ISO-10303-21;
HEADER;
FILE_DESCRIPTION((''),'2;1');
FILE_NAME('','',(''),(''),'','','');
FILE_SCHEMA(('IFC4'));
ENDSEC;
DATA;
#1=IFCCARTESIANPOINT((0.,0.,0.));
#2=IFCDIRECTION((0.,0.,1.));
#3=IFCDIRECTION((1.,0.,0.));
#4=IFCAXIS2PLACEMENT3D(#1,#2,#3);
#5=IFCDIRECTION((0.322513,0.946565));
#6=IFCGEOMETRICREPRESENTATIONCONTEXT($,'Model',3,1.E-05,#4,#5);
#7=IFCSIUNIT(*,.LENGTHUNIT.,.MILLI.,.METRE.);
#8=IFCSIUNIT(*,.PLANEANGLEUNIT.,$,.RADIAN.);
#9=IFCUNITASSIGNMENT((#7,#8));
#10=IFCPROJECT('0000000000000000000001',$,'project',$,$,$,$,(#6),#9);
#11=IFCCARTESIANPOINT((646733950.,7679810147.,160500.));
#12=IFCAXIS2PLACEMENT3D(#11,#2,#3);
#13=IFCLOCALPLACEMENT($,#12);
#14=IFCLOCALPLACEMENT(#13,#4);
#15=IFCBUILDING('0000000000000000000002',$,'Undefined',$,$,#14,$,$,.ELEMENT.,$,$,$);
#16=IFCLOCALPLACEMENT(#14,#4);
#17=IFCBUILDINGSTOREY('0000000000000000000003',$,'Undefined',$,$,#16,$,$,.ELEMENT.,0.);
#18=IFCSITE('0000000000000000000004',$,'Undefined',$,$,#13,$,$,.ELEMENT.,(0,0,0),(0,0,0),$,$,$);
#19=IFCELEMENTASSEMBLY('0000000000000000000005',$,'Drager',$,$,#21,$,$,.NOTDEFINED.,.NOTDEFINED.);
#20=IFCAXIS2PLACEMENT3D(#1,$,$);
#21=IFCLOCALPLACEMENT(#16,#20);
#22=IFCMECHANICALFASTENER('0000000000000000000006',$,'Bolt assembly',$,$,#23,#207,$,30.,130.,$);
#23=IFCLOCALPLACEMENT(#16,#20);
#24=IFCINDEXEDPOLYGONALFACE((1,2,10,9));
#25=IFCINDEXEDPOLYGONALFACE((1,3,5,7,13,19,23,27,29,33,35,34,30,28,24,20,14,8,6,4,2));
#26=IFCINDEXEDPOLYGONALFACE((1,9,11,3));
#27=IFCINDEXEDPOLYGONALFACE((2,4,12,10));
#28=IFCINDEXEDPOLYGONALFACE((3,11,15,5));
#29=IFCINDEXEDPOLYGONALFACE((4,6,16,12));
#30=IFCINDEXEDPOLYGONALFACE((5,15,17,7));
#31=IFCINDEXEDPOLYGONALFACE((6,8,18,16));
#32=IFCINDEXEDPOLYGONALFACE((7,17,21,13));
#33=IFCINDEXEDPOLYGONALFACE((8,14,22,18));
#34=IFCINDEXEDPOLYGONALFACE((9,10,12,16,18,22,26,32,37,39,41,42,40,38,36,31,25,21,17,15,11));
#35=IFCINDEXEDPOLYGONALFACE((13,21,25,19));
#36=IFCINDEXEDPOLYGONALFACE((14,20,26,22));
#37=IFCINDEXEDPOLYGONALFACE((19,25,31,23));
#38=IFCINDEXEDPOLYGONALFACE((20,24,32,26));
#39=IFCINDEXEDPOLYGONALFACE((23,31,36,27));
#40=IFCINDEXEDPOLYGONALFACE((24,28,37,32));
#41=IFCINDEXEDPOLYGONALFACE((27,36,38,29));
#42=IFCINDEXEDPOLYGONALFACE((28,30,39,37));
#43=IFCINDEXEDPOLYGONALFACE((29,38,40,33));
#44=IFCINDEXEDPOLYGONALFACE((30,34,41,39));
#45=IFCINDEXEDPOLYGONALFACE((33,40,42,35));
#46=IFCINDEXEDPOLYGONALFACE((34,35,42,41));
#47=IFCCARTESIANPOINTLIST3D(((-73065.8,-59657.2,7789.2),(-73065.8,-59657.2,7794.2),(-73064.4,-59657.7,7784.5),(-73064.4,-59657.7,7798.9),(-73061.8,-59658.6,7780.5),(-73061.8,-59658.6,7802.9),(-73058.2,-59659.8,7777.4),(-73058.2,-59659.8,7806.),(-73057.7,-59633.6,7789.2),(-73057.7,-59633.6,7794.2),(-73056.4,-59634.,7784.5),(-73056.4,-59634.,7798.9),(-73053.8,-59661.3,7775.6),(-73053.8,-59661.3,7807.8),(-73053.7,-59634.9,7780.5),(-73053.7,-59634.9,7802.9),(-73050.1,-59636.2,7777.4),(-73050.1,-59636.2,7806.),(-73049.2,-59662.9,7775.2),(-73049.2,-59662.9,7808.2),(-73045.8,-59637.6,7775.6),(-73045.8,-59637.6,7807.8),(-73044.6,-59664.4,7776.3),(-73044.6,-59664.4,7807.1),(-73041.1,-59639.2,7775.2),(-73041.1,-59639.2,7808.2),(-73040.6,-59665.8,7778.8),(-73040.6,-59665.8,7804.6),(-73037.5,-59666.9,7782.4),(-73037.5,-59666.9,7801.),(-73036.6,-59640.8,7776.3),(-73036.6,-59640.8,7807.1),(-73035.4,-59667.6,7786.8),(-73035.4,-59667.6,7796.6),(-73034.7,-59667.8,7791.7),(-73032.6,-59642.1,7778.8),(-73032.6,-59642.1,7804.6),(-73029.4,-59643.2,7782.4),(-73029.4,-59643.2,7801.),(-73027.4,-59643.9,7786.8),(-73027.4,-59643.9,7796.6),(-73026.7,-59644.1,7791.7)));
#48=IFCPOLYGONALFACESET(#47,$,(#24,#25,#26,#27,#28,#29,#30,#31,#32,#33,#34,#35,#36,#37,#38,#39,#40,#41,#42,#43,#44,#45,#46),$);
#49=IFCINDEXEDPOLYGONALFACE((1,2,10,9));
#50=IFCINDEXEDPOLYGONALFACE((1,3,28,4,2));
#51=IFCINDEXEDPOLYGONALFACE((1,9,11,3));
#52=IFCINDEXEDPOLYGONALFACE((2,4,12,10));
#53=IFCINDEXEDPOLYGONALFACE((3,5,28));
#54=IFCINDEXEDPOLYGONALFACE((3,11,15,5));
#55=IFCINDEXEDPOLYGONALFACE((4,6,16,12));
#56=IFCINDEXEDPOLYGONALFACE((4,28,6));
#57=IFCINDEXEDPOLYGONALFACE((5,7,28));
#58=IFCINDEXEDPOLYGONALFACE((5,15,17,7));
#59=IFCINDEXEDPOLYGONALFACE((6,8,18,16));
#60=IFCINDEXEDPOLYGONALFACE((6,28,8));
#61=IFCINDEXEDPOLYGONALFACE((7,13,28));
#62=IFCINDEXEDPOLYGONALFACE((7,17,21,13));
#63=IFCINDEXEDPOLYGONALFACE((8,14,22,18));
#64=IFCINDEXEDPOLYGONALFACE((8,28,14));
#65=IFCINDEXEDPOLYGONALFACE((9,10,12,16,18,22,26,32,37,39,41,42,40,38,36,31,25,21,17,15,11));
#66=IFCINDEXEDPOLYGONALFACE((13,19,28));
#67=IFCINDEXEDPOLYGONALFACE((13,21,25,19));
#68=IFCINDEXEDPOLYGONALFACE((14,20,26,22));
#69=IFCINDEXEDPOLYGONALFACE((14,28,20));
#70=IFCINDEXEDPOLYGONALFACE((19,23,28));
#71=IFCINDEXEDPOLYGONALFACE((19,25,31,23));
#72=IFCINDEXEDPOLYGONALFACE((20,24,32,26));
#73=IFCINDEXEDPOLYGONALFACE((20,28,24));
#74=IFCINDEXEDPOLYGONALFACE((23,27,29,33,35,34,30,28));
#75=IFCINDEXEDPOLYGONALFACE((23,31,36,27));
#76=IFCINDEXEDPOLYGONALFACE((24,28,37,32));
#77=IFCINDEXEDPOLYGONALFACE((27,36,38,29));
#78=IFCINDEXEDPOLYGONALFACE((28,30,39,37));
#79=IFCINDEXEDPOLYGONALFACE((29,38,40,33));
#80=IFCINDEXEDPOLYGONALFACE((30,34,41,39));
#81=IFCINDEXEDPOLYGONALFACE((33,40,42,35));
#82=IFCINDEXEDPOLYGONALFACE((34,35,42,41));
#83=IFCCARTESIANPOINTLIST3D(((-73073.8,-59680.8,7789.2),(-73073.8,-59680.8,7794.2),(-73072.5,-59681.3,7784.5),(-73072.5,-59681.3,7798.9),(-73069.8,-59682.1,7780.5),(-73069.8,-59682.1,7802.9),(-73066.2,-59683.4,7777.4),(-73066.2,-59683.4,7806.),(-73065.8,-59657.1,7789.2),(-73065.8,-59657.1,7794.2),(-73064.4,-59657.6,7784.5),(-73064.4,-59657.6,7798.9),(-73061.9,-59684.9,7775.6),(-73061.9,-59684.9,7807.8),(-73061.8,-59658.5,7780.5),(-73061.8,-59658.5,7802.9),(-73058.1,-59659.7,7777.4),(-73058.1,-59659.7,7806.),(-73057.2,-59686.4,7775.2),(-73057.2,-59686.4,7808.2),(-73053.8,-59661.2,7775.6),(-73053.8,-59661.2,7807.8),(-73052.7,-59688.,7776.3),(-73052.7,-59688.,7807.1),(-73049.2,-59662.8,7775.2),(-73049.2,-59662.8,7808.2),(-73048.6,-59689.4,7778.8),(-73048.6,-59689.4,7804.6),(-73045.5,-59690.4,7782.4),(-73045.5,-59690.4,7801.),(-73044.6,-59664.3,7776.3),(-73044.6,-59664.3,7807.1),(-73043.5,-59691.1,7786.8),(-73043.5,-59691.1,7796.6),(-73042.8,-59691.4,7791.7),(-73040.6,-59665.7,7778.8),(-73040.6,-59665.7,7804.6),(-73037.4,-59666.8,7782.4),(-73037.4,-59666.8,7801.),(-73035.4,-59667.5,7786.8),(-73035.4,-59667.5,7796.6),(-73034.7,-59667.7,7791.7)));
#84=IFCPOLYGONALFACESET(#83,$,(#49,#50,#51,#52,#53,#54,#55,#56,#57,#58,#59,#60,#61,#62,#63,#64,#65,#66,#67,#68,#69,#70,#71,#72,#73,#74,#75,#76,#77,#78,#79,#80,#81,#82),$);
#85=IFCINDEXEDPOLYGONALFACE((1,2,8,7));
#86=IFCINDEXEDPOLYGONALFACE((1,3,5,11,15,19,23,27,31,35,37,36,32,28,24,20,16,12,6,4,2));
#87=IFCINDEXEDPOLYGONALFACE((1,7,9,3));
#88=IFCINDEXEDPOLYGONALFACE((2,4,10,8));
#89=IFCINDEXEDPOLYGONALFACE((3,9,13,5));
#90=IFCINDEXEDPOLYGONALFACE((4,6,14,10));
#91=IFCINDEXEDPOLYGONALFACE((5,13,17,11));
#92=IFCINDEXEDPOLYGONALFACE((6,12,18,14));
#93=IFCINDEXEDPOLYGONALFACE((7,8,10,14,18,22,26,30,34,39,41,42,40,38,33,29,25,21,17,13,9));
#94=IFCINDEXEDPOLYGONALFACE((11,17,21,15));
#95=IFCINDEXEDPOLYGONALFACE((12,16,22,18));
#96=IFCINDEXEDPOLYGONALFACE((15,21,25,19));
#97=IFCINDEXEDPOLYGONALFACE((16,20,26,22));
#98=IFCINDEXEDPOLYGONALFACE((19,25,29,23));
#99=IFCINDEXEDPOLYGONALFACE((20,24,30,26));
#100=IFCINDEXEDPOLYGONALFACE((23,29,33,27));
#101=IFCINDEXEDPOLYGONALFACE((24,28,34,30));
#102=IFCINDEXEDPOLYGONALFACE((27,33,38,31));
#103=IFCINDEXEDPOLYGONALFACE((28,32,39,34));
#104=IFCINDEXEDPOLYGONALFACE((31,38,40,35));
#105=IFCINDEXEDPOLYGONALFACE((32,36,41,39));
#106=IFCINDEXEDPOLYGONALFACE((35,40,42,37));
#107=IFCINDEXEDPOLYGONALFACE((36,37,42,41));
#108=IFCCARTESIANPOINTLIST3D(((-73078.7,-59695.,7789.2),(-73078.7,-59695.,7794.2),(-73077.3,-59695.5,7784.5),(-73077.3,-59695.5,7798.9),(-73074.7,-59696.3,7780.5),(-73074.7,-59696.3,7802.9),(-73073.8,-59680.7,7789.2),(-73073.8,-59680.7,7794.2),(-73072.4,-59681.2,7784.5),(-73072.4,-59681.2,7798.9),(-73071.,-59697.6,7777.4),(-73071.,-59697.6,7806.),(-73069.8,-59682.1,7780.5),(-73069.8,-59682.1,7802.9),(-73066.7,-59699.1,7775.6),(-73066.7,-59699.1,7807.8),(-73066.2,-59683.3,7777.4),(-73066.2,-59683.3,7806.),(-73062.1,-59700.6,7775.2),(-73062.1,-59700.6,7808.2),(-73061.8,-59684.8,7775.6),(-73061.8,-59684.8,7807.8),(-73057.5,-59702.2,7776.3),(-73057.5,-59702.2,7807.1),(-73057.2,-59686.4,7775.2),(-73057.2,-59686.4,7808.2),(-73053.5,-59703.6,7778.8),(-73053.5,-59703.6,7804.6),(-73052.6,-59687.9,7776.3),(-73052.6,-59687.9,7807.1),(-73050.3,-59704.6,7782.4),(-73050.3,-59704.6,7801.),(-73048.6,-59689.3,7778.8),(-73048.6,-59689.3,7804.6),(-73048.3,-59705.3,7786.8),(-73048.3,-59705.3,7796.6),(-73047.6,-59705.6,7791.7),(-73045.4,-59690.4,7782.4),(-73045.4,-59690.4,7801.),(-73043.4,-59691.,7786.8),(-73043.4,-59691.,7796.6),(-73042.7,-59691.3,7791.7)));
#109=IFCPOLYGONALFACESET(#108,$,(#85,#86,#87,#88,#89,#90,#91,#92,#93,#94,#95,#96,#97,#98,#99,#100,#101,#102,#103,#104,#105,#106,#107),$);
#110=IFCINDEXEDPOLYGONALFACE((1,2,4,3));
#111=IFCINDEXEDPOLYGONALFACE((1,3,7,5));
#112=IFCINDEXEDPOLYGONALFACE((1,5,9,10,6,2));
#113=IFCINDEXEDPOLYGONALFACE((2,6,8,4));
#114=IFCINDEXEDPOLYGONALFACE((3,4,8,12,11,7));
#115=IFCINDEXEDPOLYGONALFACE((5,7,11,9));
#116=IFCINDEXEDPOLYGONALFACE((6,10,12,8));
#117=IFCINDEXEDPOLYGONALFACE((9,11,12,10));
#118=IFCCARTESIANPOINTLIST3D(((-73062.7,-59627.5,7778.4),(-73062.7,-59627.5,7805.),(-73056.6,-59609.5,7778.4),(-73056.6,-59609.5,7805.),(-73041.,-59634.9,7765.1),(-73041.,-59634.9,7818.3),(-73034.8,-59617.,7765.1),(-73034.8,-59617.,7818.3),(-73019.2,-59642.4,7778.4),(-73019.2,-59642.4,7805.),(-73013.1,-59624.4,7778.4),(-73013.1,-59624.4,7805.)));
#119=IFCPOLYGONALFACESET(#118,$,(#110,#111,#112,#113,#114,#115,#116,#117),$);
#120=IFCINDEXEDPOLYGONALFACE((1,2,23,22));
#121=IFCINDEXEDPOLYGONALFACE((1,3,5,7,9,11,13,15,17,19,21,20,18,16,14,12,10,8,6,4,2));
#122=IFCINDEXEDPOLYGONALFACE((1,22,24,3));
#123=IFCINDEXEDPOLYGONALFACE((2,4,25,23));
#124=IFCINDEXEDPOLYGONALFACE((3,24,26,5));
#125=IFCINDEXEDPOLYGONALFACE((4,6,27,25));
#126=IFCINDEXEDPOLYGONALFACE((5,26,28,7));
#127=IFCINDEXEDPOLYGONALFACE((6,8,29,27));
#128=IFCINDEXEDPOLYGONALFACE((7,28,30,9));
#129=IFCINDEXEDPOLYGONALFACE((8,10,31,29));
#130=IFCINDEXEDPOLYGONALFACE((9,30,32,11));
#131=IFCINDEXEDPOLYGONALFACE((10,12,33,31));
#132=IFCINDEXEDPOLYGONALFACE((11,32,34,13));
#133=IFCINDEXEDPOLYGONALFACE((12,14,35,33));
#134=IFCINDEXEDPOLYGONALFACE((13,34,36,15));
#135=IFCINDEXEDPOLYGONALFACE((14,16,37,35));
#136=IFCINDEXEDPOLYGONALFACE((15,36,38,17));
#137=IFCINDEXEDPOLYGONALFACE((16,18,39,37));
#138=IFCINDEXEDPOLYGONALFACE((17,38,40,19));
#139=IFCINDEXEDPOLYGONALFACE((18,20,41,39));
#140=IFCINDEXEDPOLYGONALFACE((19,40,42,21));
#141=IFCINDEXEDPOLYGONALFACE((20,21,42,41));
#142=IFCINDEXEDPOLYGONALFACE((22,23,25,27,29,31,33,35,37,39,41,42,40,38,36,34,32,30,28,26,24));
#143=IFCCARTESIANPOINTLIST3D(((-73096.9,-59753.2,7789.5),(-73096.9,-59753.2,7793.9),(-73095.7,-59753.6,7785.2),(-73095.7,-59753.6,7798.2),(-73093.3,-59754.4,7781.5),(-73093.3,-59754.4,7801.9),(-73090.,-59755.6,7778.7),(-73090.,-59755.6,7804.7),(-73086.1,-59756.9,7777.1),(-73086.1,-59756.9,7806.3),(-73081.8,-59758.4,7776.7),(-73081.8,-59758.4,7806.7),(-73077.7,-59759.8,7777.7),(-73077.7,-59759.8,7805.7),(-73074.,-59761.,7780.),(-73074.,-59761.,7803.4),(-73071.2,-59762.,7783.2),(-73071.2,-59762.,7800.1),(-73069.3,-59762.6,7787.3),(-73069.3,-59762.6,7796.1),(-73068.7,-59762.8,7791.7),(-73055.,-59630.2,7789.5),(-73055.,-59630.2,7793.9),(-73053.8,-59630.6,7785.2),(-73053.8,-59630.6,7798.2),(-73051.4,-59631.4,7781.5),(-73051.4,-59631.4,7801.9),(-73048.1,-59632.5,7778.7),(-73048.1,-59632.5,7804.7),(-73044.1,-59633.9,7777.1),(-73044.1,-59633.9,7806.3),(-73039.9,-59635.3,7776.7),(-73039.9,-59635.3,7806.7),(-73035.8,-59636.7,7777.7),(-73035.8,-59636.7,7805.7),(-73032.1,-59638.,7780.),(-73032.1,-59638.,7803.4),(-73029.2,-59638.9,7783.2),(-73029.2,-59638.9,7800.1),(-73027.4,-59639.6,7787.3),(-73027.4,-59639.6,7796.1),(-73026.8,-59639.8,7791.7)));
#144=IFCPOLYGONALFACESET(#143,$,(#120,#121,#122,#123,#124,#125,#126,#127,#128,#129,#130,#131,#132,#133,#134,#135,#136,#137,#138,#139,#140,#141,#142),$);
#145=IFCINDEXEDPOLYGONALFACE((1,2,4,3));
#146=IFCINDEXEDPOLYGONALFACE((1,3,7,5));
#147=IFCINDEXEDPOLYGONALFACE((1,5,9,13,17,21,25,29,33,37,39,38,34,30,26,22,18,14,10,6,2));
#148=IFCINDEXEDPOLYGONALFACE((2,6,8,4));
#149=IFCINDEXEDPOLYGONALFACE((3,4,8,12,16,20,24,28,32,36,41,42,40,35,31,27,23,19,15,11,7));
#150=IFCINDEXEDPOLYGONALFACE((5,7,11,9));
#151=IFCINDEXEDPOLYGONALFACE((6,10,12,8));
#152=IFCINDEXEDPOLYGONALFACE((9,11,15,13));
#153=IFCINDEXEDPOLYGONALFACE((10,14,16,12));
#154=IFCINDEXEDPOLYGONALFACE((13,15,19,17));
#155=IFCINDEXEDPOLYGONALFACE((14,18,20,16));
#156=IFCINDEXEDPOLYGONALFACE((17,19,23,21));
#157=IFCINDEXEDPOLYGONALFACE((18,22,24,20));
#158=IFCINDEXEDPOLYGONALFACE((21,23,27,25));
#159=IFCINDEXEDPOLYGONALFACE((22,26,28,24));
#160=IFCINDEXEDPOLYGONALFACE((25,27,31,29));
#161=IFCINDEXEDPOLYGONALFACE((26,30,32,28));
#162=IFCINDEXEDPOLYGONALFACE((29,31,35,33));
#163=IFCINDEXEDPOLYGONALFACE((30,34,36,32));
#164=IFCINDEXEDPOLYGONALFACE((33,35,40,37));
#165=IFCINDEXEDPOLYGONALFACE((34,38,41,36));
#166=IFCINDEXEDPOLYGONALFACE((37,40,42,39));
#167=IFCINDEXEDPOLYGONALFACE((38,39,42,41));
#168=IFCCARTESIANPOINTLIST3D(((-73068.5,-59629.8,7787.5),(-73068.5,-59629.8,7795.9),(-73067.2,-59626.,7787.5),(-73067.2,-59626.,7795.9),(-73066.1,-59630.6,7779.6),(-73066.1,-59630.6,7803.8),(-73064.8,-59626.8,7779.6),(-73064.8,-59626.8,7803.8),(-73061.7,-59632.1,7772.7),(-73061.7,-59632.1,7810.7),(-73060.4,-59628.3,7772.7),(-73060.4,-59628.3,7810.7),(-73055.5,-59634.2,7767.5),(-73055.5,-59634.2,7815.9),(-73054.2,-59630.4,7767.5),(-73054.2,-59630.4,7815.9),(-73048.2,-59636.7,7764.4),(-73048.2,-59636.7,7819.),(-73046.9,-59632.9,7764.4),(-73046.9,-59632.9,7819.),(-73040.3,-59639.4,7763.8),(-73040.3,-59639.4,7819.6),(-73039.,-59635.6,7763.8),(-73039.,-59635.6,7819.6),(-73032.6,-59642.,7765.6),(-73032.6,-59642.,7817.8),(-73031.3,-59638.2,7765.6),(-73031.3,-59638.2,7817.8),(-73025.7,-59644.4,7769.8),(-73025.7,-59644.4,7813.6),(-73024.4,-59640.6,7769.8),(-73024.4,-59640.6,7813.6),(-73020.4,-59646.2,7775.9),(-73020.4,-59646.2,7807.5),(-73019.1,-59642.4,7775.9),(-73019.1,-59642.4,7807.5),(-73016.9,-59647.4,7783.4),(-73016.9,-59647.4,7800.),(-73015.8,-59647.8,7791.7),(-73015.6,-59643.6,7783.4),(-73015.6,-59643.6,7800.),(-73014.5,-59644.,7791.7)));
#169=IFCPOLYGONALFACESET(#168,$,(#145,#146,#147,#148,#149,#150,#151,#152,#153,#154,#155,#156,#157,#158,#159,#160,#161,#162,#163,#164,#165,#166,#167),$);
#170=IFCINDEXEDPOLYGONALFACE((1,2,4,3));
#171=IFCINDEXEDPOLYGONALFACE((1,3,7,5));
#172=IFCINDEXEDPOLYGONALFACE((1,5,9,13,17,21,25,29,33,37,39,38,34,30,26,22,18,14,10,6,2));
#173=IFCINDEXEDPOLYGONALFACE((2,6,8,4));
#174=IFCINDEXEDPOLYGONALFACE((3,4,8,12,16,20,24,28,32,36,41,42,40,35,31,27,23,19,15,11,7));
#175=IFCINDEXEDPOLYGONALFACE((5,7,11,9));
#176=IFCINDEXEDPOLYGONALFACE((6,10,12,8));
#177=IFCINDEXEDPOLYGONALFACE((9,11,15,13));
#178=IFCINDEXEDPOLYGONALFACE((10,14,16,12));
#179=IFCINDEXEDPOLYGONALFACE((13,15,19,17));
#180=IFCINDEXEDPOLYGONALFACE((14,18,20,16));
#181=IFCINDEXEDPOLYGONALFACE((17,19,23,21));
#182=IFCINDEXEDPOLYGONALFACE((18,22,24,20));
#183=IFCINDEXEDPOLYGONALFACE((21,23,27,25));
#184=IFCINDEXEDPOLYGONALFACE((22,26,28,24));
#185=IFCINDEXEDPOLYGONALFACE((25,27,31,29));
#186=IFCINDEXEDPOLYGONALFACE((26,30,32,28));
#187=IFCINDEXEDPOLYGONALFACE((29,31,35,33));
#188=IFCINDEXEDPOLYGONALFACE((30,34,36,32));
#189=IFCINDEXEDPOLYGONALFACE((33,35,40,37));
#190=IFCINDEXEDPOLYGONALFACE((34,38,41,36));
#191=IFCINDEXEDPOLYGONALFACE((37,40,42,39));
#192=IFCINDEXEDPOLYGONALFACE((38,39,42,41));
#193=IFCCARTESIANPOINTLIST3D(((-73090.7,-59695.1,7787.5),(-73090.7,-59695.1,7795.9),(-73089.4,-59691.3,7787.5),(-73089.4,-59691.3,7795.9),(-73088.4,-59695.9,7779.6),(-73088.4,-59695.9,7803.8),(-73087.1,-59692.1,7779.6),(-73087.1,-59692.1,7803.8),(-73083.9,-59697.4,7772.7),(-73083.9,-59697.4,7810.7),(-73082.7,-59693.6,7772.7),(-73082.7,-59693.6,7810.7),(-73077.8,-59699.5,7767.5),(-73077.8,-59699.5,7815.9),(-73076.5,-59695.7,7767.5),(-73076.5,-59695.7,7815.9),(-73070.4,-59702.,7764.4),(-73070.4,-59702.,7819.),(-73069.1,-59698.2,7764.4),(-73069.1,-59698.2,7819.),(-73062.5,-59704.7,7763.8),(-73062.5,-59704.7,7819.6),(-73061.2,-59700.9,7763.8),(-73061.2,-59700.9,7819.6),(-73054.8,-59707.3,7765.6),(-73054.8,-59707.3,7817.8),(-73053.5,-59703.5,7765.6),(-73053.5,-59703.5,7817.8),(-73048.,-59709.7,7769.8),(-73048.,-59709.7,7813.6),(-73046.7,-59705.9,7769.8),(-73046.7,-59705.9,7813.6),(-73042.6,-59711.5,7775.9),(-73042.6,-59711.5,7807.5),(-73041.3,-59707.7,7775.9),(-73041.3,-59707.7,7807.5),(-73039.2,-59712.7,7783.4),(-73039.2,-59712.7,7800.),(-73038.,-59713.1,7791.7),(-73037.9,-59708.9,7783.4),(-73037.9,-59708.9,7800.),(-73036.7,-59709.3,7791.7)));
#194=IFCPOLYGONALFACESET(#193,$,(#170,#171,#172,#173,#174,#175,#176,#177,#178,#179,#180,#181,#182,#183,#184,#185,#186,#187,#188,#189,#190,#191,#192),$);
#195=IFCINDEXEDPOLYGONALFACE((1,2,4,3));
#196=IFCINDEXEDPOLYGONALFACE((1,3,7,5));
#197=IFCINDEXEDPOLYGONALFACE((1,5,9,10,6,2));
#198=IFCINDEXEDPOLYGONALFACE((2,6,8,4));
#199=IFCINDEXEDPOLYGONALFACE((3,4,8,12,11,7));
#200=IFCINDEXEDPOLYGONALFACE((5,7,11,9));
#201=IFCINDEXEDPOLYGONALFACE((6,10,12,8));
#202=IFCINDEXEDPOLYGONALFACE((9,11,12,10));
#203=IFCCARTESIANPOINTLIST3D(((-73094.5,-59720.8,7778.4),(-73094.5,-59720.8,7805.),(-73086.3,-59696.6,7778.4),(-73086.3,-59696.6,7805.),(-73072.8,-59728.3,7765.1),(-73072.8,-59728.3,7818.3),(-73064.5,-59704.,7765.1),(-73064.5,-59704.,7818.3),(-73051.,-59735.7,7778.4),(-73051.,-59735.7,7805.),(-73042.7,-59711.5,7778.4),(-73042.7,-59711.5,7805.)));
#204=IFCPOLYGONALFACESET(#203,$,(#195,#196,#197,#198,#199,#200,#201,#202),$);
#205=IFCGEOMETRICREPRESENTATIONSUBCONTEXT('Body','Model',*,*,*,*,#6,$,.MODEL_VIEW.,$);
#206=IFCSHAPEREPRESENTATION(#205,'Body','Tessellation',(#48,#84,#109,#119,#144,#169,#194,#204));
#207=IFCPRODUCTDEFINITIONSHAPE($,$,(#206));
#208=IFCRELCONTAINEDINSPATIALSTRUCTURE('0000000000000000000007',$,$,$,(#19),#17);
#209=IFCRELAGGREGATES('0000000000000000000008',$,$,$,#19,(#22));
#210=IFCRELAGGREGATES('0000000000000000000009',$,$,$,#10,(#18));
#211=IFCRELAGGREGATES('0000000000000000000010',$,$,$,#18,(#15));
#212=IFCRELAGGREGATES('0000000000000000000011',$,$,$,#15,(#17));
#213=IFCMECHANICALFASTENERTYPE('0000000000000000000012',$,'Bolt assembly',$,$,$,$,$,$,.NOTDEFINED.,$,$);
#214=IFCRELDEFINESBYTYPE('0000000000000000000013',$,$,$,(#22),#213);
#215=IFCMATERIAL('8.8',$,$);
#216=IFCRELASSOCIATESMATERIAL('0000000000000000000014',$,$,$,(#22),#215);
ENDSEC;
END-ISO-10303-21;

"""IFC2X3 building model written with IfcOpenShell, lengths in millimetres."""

from ifc_helpers import new_model, si_unit, direction, frame, origin_with_axes, origin_2d_with_axis, place, context, subcontext, project, spatial, polyline, circle, outline, extrude, source, transform, mapped, material, type_object, element, aggregate, save


model = new_model("IFC2X3")

# Units and contexts
model_context = context("Model", 3, precision=1e-05, world=origin_with_axes(), true_north=direction((0.322513, 0.946565)))
body_context = subcontext(model_context, "Body", "Model", "MODEL_VIEW")
ifc_project = project(units=[si_unit("LENGTHUNIT", "METRE", prefix="MILLI"), si_unit("PLANEANGLEUNIT", "RADIAN")], contexts=[model_context])

# Site, building, storey
site_placement = place(None, frame((646733950.0, 7679810147.0, 160500.0), z_axis=(0.0, 0.0, 1.0), x_axis=(1.0, 0.0, 0.0)))
site = spatial("IfcSite", under=ifc_project, at=site_placement, Name="Undefined", CompositionType="ELEMENT", RefLatitude=(0, 0, 0), RefLongitude=(0, 0, 0))
building_placement = place(site_placement, origin_with_axes())
building = spatial("IfcBuilding", under=site, at=building_placement, Name="Undefined", CompositionType="ELEMENT")
storey_placement = place(building_placement, origin_with_axes())
storey = spatial("IfcBuildingStorey", under=building, at=storey_placement, Name="Undefined", CompositionType="ELEMENT", Elevation=0.0)

# Shared definitions
ifc_material_1 = material(Name="8.8")
mechanical_fastener_type = type_object("IfcMechanicalFastenerType", Name="Bolt assembly")

# Element assembly, mechanical fastener
assembly_1_placement = place(storey_placement, origin_with_axes())
assembly_1 = element("IfcElementAssembly", 1, at=assembly_1_placement, inside=storey, Name="Drager", AssemblyPlace="NOTDEFINED", PredefinedType="NOTDEFINED")
shared_shape_1 = source(origin_with_axes(), body_context, "Body", "SweptSolid", [
    extrude(circle(Radius=16.5, at=origin_2d_with_axis()), frame((0.0, -57.4, 0.0), z_axis=(0.0, 1.0, 0.0), x_axis=(1.0, 0.0, 0.0)), (0.0, 0.0, 1.0), 25.0),
    extrude(circle(Radius=16.5, at=origin_2d_with_axis()), frame((0.0, -32.5, 0.0), z_axis=(0.0, 1.0, 0.0), x_axis=(1.0, 0.0, 0.0)), (0.0, 0.0, 1.0), 25.0),
    extrude(circle(Radius=16.5, at=origin_2d_with_axis()), frame((0.0, -7.6, 0.0), z_axis=(0.0, 1.0, 0.0), x_axis=(1.0, 0.0, 0.0)), (0.0, 0.0, 1.0), 15.1),
    extrude(outline(polyline([(23.0, -13.3), (23.0, 13.3), (0.0, 26.6), (-23.0, 13.3), (-23.0, -13.3), (0.0, -26.6), (23.0, -13.3)])), frame((0.0, -80.5, 0.0), z_axis=(0.0, 1.0, 0.0), x_axis=(1.0, 0.0, 0.0)), (0.0, 0.0, 1.0), 19.0),
    extrude(circle(Radius=15.0, at=origin_2d_with_axis()), frame((0.0, -61.5, 0.0), z_axis=(0.0, 1.0, 0.0), x_axis=(1.0, 0.0, 0.0)), (0.0, 0.0, 1.0), 130.0),
    extrude(circle(Radius=28.0, at=origin_2d_with_axis()), frame((0.0, -61.5, 0.0), z_axis=(0.0, 1.0, 0.0), x_axis=(1.0, 0.0, 0.0)), (0.0, 0.0, 1.0), 4.0),
    extrude(circle(Radius=28.0, at=origin_2d_with_axis()), frame((0.0, 7.5, 0.0), z_axis=(0.0, 1.0, 0.0), x_axis=(1.0, 0.0, 0.0)), (0.0, 0.0, 1.0), 4.0),
    extrude(outline(polyline([(23.0, -13.3), (23.0, 13.3), (0.0, 26.6), (-23.0, 13.3), (-23.0, -13.3), (0.0, -26.6), (23.0, -13.3)])), frame((0.0, 11.5, 0.0), z_axis=(0.0, 1.0, 0.0), x_axis=(1.0, 0.0, 0.0)), (0.0, 0.0, 1.0), 25.6),
])
mechanical_fastener_1_placement = place(assembly_1_placement, frame((-73060.8, -59693.2, 7791.7), z_axis=(0.0, 0.0, -1.0), x_axis=(0.946565, -0.322513, 0.0)))
mechanical_fastener_1 = element("IfcMechanicalFastener", 2, at=mechanical_fastener_1_placement, type_object=mechanical_fastener_type, material=ifc_material_1, Name="Bolt assembly", NominalDiameter=30.0, NominalLength=130.0, context=body_context, shape_type="MappedRepresentation", body=[
    mapped(shared_shape_1, transform((0.0, 0.0, 0.0))),
])
aggregate(assembly_1, [mechanical_fastener_1])

save(model, "model.ifc")
